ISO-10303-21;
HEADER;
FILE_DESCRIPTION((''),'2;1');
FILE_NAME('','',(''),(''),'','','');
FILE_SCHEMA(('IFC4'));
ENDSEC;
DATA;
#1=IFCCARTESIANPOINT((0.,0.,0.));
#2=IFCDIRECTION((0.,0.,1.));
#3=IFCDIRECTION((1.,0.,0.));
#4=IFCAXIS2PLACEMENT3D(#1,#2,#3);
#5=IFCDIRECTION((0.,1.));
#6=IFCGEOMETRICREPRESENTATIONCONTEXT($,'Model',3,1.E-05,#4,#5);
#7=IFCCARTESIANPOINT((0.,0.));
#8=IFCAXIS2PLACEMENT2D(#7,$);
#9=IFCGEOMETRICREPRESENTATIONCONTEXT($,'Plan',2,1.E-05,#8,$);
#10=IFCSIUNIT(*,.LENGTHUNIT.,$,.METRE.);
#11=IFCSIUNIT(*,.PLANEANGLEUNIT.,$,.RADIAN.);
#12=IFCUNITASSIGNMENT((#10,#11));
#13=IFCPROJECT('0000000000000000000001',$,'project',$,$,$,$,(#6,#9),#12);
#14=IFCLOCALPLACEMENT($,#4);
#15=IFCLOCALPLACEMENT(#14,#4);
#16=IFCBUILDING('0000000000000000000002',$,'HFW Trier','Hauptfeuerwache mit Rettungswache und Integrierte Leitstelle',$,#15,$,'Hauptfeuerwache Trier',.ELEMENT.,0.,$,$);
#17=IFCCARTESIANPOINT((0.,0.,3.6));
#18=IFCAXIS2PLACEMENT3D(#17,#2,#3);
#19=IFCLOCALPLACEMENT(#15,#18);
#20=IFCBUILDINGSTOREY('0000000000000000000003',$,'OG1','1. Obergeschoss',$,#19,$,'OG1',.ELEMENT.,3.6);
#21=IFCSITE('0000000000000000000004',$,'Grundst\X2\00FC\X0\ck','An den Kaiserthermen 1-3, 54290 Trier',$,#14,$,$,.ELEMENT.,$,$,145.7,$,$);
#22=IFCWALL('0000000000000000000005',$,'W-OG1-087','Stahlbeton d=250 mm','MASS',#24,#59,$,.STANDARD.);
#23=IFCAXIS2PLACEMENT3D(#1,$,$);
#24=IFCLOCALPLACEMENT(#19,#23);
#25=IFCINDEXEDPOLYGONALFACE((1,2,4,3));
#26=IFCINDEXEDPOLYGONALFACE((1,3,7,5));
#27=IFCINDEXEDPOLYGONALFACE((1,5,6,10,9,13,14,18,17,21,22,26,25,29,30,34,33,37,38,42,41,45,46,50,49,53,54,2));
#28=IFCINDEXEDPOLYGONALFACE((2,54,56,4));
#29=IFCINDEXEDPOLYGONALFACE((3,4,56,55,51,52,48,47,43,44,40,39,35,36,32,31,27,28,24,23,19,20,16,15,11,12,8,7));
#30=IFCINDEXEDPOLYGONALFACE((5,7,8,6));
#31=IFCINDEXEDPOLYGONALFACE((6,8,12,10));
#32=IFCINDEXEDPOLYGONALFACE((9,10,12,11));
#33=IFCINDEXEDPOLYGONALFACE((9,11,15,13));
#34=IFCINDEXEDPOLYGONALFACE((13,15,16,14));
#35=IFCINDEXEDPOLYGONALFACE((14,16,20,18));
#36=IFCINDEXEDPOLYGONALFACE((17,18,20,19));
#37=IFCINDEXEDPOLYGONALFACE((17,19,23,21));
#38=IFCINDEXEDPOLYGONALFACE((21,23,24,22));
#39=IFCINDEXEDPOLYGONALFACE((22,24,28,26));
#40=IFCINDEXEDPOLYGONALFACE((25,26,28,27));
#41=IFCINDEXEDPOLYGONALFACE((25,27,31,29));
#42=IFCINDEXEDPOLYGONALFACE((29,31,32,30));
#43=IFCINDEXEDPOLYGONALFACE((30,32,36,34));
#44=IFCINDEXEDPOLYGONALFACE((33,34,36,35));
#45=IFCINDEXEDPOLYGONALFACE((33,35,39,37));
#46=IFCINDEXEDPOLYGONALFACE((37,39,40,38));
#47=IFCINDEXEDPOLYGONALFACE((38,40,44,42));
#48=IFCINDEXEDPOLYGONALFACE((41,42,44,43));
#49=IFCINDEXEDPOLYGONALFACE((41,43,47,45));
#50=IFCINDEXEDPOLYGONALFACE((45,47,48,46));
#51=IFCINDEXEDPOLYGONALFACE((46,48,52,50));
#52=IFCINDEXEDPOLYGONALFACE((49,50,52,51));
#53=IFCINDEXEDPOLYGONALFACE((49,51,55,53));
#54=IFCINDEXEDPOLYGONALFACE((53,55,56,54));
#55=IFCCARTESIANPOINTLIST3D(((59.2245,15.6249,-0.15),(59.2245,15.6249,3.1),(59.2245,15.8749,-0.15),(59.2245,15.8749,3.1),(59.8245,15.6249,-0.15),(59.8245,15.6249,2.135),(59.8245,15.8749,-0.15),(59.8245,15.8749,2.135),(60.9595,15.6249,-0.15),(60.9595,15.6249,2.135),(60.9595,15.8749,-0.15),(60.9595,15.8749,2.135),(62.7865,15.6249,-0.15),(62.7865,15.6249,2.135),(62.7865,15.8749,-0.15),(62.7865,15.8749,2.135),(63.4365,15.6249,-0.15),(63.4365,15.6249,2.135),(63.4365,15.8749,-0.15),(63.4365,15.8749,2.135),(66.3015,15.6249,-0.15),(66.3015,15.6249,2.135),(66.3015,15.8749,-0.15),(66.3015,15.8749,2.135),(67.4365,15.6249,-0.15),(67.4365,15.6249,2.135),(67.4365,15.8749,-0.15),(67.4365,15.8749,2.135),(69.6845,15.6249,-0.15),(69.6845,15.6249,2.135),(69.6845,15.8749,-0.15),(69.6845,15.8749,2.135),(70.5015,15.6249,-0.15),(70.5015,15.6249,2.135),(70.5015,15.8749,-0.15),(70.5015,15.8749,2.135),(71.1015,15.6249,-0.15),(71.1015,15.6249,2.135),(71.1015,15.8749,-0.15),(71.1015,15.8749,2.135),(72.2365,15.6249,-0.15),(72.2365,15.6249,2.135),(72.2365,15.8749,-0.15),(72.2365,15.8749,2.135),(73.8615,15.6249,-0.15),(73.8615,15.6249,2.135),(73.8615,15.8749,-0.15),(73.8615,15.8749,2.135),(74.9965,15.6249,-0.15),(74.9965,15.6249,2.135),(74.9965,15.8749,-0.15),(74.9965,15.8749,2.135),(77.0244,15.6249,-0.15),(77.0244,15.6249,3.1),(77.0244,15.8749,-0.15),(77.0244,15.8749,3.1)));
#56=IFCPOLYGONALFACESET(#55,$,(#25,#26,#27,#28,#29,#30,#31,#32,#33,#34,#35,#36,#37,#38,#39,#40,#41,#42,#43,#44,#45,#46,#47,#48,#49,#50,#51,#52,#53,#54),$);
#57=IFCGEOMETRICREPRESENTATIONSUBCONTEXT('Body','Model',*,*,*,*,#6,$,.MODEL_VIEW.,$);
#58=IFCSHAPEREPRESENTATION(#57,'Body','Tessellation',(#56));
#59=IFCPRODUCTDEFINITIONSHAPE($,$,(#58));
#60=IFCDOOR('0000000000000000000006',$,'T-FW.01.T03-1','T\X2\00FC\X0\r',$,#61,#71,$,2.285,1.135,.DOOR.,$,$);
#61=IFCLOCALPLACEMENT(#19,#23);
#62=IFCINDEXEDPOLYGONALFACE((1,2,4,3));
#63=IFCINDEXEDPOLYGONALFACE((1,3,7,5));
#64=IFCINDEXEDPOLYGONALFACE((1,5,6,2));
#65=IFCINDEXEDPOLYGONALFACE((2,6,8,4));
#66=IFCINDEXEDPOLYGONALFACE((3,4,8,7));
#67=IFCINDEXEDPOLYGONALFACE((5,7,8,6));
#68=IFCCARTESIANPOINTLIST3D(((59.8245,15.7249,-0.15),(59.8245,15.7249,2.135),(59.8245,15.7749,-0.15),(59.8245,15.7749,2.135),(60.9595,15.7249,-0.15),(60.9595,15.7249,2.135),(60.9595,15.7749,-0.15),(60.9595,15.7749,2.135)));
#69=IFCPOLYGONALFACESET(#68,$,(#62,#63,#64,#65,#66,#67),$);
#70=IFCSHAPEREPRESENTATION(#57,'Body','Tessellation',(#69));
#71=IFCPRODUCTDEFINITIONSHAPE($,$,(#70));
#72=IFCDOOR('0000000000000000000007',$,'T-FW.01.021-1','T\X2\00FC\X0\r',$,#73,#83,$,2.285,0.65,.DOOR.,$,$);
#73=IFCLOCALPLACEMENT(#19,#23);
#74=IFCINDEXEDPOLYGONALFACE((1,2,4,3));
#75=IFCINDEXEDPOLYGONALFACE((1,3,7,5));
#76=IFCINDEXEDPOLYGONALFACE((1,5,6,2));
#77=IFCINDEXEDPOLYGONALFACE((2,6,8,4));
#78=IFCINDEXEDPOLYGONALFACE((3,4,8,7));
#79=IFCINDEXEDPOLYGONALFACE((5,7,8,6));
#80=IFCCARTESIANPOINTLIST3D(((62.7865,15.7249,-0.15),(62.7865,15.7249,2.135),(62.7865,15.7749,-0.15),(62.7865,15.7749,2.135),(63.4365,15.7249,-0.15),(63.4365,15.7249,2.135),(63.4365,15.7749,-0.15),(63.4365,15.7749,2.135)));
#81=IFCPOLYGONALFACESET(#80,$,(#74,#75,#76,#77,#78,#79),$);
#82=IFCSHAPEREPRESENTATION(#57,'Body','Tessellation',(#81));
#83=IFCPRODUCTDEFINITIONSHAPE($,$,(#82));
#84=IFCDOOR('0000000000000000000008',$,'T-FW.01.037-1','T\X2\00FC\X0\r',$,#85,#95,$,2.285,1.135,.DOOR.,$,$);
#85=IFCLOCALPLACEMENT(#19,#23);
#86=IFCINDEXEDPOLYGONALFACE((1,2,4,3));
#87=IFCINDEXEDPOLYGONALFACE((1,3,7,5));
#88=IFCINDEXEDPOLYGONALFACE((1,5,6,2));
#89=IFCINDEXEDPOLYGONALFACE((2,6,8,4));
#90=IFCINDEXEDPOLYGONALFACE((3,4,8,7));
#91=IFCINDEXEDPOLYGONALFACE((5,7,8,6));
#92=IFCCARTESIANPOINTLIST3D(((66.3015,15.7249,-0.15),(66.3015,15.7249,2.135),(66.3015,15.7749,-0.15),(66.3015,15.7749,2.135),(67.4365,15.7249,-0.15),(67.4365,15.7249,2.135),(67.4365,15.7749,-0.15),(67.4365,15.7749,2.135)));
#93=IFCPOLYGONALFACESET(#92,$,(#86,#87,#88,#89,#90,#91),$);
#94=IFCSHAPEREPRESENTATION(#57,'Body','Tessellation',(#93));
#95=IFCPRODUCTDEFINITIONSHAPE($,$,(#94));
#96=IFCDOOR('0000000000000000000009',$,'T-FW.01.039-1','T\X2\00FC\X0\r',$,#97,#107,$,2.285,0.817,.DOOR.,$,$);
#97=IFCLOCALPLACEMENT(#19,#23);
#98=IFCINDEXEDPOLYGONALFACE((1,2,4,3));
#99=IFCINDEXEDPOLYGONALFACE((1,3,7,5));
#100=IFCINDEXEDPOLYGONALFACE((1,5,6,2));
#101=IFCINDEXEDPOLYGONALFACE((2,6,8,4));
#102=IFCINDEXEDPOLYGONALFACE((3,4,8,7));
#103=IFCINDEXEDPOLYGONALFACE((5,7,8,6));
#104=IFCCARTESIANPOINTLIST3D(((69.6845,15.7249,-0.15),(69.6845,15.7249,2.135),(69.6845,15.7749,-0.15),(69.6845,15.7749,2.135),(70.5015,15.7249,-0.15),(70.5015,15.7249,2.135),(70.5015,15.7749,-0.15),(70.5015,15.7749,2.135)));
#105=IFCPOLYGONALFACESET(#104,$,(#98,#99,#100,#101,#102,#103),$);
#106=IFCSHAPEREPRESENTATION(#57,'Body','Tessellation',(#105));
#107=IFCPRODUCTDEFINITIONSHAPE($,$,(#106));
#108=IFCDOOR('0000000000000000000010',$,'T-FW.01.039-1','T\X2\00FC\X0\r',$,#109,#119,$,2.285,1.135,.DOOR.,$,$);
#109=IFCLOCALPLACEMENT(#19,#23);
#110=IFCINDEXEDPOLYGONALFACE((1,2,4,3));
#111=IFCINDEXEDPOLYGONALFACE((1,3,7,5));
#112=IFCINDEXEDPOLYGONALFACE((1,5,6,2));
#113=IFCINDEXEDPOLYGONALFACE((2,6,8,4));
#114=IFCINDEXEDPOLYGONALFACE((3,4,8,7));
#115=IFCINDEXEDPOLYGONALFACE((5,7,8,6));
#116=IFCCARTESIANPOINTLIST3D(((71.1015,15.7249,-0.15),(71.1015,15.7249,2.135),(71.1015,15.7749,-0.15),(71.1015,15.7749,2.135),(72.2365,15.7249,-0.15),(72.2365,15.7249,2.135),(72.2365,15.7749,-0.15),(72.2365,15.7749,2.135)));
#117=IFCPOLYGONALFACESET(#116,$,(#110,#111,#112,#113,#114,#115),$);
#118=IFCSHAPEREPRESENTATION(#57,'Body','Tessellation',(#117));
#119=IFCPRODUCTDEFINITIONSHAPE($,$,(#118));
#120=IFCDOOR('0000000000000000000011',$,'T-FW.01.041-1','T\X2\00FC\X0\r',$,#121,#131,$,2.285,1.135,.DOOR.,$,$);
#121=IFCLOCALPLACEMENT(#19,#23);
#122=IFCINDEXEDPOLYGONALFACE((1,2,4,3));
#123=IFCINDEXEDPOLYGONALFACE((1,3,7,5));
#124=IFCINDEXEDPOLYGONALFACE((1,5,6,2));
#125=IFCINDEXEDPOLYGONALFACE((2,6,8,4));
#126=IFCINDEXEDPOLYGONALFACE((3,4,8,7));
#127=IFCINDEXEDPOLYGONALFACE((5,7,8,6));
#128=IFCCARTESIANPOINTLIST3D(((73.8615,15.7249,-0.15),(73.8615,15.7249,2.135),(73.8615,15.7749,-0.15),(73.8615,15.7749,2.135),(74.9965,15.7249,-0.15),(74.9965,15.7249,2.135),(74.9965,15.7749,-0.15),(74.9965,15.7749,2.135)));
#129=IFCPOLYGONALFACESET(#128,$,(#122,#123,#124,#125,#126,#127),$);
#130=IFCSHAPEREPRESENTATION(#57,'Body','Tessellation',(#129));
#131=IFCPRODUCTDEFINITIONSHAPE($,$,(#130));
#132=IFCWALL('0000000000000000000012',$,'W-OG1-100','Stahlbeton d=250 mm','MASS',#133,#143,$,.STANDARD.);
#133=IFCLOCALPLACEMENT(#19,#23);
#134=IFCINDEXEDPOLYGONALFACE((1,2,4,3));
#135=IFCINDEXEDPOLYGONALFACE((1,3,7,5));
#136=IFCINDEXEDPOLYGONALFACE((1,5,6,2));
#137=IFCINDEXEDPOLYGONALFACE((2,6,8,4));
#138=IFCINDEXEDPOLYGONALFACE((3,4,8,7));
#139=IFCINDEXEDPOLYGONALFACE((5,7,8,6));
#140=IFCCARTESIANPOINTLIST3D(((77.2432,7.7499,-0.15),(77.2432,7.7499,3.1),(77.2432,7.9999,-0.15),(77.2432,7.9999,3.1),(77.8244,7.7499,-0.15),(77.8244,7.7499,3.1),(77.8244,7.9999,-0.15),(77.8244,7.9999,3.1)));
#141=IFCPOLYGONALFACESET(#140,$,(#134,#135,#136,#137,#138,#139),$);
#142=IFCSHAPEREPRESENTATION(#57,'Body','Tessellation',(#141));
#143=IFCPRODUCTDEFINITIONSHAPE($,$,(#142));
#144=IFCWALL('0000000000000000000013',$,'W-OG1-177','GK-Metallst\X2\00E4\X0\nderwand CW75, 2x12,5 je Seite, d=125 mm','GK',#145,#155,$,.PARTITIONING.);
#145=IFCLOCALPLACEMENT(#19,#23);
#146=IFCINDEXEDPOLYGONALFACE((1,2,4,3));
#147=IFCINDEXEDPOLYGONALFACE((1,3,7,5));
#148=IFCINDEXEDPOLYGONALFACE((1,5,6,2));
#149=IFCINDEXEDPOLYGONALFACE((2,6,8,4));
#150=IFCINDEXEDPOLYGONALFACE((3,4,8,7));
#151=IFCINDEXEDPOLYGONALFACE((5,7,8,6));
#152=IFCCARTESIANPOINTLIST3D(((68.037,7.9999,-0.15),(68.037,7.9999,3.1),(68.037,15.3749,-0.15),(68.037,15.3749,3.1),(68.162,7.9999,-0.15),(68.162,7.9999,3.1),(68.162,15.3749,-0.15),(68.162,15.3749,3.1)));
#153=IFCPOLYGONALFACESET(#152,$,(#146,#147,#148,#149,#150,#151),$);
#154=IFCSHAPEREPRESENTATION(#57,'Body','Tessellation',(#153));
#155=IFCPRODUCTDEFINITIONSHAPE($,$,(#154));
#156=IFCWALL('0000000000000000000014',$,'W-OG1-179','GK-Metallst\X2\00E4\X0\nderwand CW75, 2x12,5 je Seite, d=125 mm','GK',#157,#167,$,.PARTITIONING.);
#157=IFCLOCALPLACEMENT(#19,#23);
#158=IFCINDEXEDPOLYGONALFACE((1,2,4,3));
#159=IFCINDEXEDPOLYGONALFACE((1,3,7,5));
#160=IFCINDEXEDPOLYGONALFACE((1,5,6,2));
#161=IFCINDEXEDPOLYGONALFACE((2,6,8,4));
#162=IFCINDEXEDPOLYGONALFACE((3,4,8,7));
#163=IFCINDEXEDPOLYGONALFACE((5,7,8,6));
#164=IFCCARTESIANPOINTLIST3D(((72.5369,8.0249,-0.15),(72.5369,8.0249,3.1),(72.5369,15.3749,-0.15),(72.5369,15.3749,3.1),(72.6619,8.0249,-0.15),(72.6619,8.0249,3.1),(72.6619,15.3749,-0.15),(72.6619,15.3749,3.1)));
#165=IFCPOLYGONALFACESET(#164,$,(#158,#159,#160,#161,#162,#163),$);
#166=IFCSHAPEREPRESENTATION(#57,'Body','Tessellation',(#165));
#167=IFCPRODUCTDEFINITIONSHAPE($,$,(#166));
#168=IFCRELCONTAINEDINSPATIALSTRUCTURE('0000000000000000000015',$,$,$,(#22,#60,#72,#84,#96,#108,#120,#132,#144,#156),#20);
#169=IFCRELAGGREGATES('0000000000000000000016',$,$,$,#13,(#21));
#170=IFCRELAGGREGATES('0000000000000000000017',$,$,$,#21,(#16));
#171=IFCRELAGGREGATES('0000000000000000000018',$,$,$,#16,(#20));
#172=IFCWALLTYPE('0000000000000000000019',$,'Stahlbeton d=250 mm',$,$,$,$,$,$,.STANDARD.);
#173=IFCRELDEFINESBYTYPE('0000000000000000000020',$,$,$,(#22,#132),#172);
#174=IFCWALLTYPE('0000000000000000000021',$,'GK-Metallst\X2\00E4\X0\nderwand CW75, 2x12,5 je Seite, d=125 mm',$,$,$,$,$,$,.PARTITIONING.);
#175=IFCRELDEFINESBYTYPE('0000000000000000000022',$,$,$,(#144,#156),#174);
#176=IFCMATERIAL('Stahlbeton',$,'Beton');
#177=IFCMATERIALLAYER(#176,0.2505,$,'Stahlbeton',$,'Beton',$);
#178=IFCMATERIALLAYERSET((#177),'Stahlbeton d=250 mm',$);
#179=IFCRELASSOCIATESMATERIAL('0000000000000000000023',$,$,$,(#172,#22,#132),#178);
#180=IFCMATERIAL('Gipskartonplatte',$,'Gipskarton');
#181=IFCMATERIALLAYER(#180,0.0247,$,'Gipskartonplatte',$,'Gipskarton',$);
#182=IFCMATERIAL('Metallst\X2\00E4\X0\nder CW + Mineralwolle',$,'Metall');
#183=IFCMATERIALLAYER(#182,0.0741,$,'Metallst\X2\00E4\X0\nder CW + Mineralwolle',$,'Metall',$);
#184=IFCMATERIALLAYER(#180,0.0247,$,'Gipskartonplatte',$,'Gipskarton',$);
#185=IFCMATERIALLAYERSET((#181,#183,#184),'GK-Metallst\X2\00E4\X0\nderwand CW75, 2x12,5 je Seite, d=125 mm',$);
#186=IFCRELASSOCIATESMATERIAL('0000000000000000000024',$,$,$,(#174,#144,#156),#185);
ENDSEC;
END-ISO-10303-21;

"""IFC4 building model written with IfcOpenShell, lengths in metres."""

from ifc_helpers import new_model, si_unit, direction, frame, frame_2d, origin_with_axes, origin_2d, place, context, subcontext, project, spatial, rectangle, extrude, material, layer, layer_set, layer_usage, type_object, element, fill, save


model = new_model("IFC4")

# Units and contexts
model_context = context("Model", 3, precision=1e-05, world=origin_with_axes(), true_north=direction((0.0, 1.0)))
plan_context = context("Plan", 2, precision=1e-05, world=origin_2d())
body_context = subcontext(model_context, "Body", "Model", "MODEL_VIEW")
ifc_project = project(units=[si_unit("LENGTHUNIT", "METRE"), si_unit("PLANEANGLEUNIT", "RADIAN")], contexts=[model_context, plan_context])

# Site, building, storey
site_placement = place(None, origin_with_axes())
site = spatial("IfcSite", under=ifc_project, at=site_placement, Name="Grundstück", Description="An den Kaiserthermen 1-3, 54290 Trier", CompositionType="ELEMENT", RefElevation=145.7)
building_placement = place(site_placement, origin_with_axes())
building = spatial("IfcBuilding", under=site, at=building_placement, Name="HFW Trier", Description="Hauptfeuerwache mit Rettungswache und Integrierte Leitstelle", LongName="Hauptfeuerwache Trier", CompositionType="ELEMENT", ElevationOfRefHeight=0.0)
storey_placement = place(building_placement, frame((0.0, 0.0, 3.6), z_axis=(0.0, 0.0, 1.0), x_axis=(1.0, 0.0, 0.0)))
storey = spatial("IfcBuildingStorey", under=building, at=storey_placement, Name="OG1", Description="1. Obergeschoss", LongName="OG1", CompositionType="ELEMENT", Elevation=3.6)

# Wall, openings, doors
ifc_material_1 = material(Name="Stahlbeton", Category="Beton")
ifc_layer_1 = layer(ifc_material_1, 0.2505, Name="Stahlbeton", Category="Beton")
ifc_layer_set_1 = layer_set([ifc_layer_1], Name="Stahlbeton d=250 mm")
wall_type_1 = type_object("IfcWallType", Name="Stahlbeton d=250 mm", PredefinedType="STANDARD", material=ifc_layer_set_1)
ifc_layer_usage_1 = layer_usage(ifc_layer_set_1, "AXIS2", "POSITIVE", -0.125)
wall_1_placement = place(storey_placement, frame((59.2245, 15.7499, -0.15), z_axis=(0.0, 0.0, 1.0), x_axis=(1.0, 0.0, 0.0)))
wall_1 = element("IfcWall", 1, at=wall_1_placement, inside=storey, type_object=wall_type_1, material=ifc_layer_usage_1, Name="W-OG1-087", Description="Stahlbeton d=250 mm", ObjectType="MASS", PredefinedType="STANDARD", context=body_context, shape_type="SweptSolid", body=[
    extrude(rectangle(XDim=17.7999, YDim=0.25, at=frame_2d((8.9, 0.0))), origin_with_axes(), (0.0, 0.0, 1.0), 3.25),
])
opening_1_placement = place(wall_1_placement, frame((0.6, 0.0, 0.0), z_axis=(0.0, 0.0, 1.0), x_axis=(1.0, 0.0, 0.0)))
opening_1 = element("IfcOpeningElement", 2, at=opening_1_placement, cuts=wall_1, PredefinedType="OPENING", context=body_context, shape_type="SweptSolid", body=[
    extrude(rectangle(XDim=1.135, YDim=0.35, at=frame_2d((0.5675, 0.0))), origin_with_axes(), (0.0, 0.0, 1.0), 2.285),
])
opening_2_placement = place(wall_1_placement, frame((3.562, 0.0, 0.0), z_axis=(0.0, 0.0, 1.0), x_axis=(1.0, 0.0, 0.0)))
opening_2 = element("IfcOpeningElement", 3, at=opening_2_placement, cuts=wall_1, PredefinedType="OPENING", context=body_context, shape_type="SweptSolid", body=[
    extrude(rectangle(XDim=0.65, YDim=0.35, at=frame_2d((0.325, 0.0))), origin_with_axes(), (0.0, 0.0, 1.0), 2.285),
])
opening_3_placement = place(wall_1_placement, frame((7.077, 0.0, 0.0), z_axis=(0.0, 0.0, 1.0), x_axis=(1.0, 0.0, 0.0)))
opening_3 = element("IfcOpeningElement", 4, at=opening_3_placement, cuts=wall_1, PredefinedType="OPENING", context=body_context, shape_type="SweptSolid", body=[
    extrude(rectangle(XDim=1.135, YDim=0.35, at=frame_2d((0.5675, 0.0))), origin_with_axes(), (0.0, 0.0, 1.0), 2.285),
])
opening_4_placement = place(wall_1_placement, frame((10.46, 0.0, 0.0), z_axis=(0.0, 0.0, 1.0), x_axis=(1.0, 0.0, 0.0)))
opening_4 = element("IfcOpeningElement", 5, at=opening_4_placement, cuts=wall_1, PredefinedType="OPENING", context=body_context, shape_type="SweptSolid", body=[
    extrude(rectangle(XDim=0.817, YDim=0.35, at=frame_2d((0.4085, 0.0))), origin_with_axes(), (0.0, 0.0, 1.0), 2.285),
])
opening_5_placement = place(wall_1_placement, frame((11.877, 0.0, 0.0), z_axis=(0.0, 0.0, 1.0), x_axis=(1.0, 0.0, 0.0)))
opening_5 = element("IfcOpeningElement", 6, at=opening_5_placement, cuts=wall_1, PredefinedType="OPENING", context=body_context, shape_type="SweptSolid", body=[
    extrude(rectangle(XDim=1.135, YDim=0.35, at=frame_2d((0.5675, 0.0))), origin_with_axes(), (0.0, 0.0, 1.0), 2.285),
])
opening_6_placement = place(wall_1_placement, frame((14.637, 0.0, 0.0), z_axis=(0.0, 0.0, 1.0), x_axis=(1.0, 0.0, 0.0)))
opening_6 = element("IfcOpeningElement", 7, at=opening_6_placement, cuts=wall_1, PredefinedType="OPENING", context=body_context, shape_type="SweptSolid", body=[
    extrude(rectangle(XDim=1.135, YDim=0.35, at=frame_2d((0.5675, 0.0))), origin_with_axes(), (0.0, 0.0, 1.0), 2.285),
])
door_1_placement = place(wall_1_placement, frame((0.6, 0.0, 0.0), z_axis=(0.0, 0.0, 1.0), x_axis=(1.0, 0.0, 0.0)))
door_1 = element("IfcDoor", 8, at=door_1_placement, inside=storey, Name="T-FW.01.T03-1", Description="Tür", OverallHeight=2.285, OverallWidth=1.135, PredefinedType="DOOR", context=body_context, shape_type="SweptSolid", body=[
    extrude(rectangle(XDim=1.135, YDim=0.05, at=frame_2d((0.5675, 0.0))), origin_with_axes(), (0.0, 0.0, 1.0), 2.285),
])
fill(opening_1, door_1)
door_2_placement = place(wall_1_placement, frame((3.562, 0.0, 0.0), z_axis=(0.0, 0.0, 1.0), x_axis=(1.0, 0.0, 0.0)))
door_2 = element("IfcDoor", 9, at=door_2_placement, inside=storey, Name="T-FW.01.021-1", Description="Tür", OverallHeight=2.285, OverallWidth=0.65, PredefinedType="DOOR", context=body_context, shape_type="SweptSolid", body=[
    extrude(rectangle(XDim=0.65, YDim=0.05, at=frame_2d((0.325, 0.0))), origin_with_axes(), (0.0, 0.0, 1.0), 2.285),
])
fill(opening_2, door_2)
door_3_placement = place(wall_1_placement, frame((7.077, 0.0, 0.0), z_axis=(0.0, 0.0, 1.0), x_axis=(1.0, 0.0, 0.0)))
door_3 = element("IfcDoor", 10, at=door_3_placement, inside=storey, Name="T-FW.01.037-1", Description="Tür", OverallHeight=2.285, OverallWidth=1.135, PredefinedType="DOOR", context=body_context, shape_type="SweptSolid", body=[
    extrude(rectangle(XDim=1.135, YDim=0.05, at=frame_2d((0.5675, 0.0))), origin_with_axes(), (0.0, 0.0, 1.0), 2.285),
])
fill(opening_3, door_3)
door_4_placement = place(wall_1_placement, frame((10.46, 0.0, 0.0), z_axis=(0.0, 0.0, 1.0), x_axis=(1.0, 0.0, 0.0)))
door_4 = element("IfcDoor", 11, at=door_4_placement, inside=storey, Name="T-FW.01.039-1", Description="Tür", OverallHeight=2.285, OverallWidth=0.817, PredefinedType="DOOR", context=body_context, shape_type="SweptSolid", body=[
    extrude(rectangle(XDim=0.817, YDim=0.05, at=frame_2d((0.4085, 0.0))), origin_with_axes(), (0.0, 0.0, 1.0), 2.285),
])
fill(opening_4, door_4)
door_5_placement = place(wall_1_placement, frame((11.877, 0.0, 0.0), z_axis=(0.0, 0.0, 1.0), x_axis=(1.0, 0.0, 0.0)))
door_5 = element("IfcDoor", 12, at=door_5_placement, inside=storey, Name="T-FW.01.039-1", Description="Tür", OverallHeight=2.285, OverallWidth=1.135, PredefinedType="DOOR", context=body_context, shape_type="SweptSolid", body=[
    extrude(rectangle(XDim=1.135, YDim=0.05, at=frame_2d((0.5675, 0.0))), origin_with_axes(), (0.0, 0.0, 1.0), 2.285),
])
fill(opening_5, door_5)
door_6_placement = place(wall_1_placement, frame((14.637, 0.0, 0.0), z_axis=(0.0, 0.0, 1.0), x_axis=(1.0, 0.0, 0.0)))
door_6 = element("IfcDoor", 13, at=door_6_placement, inside=storey, Name="T-FW.01.041-1", Description="Tür", OverallHeight=2.285, OverallWidth=1.135, PredefinedType="DOOR", context=body_context, shape_type="SweptSolid", body=[
    extrude(rectangle(XDim=1.135, YDim=0.05, at=frame_2d((0.5675, 0.0))), origin_with_axes(), (0.0, 0.0, 1.0), 2.285),
])
fill(opening_6, door_6)

# Walls
ifc_layer_usage_2 = layer_usage(ifc_layer_set_1, "AXIS2", "POSITIVE", -0.125)
wall_2_placement = place(storey_placement, frame((77.2432, 7.8749, -0.15), z_axis=(0.0, 0.0, 1.0), x_axis=(1.0, 0.0, 0.0)))
element("IfcWall", 14, at=wall_2_placement, inside=storey, type_object=wall_type_1, material=ifc_layer_usage_2, Name="W-OG1-100", Description="Stahlbeton d=250 mm", ObjectType="MASS", PredefinedType="STANDARD", context=body_context, shape_type="SweptSolid", body=[
    extrude(rectangle(XDim=0.5812, YDim=0.25, at=frame_2d((0.2906, 0.0))), origin_with_axes(), (0.0, 0.0, 1.0), 3.25),
])
ifc_material_2 = material(Name="Gipskartonplatte", Category="Gipskarton")
ifc_layer_2 = layer(ifc_material_2, 0.0247, Name="Gipskartonplatte", Category="Gipskarton")
ifc_material_3 = material(Name="Metallständer CW + Mineralwolle", Category="Metall")
ifc_layer_3 = layer(ifc_material_3, 0.0741, Name="Metallständer CW + Mineralwolle", Category="Metall")
ifc_layer_4 = layer(ifc_material_2, 0.0247, Name="Gipskartonplatte", Category="Gipskarton")
ifc_layer_set_2 = layer_set([ifc_layer_2, ifc_layer_3, ifc_layer_4], Name="GK-Metallständerwand CW75, 2x12,5 je Seite, d=125 mm")
ifc_layer_usage_3 = layer_usage(ifc_layer_set_2, "AXIS2", "POSITIVE", -0.0625)
wall_type_2 = type_object("IfcWallType", Name="GK-Metallständerwand CW75, 2x12,5 je Seite, d=125 mm", PredefinedType="PARTITIONING", material=ifc_layer_set_2)
wall_3_placement = place(storey_placement, frame((68.0995, 15.3749, -0.15), z_axis=(0.0, 0.0, 1.0), x_axis=(0.0, -1.0, 0.0)))
element("IfcWall", 15, at=wall_3_placement, inside=storey, type_object=wall_type_2, material=ifc_layer_usage_3, Name="W-OG1-177", Description="GK-Metallständerwand CW75, 2x12,5 je Seite, d=125 mm", ObjectType="GK", PredefinedType="PARTITIONING", context=body_context, shape_type="SweptSolid", body=[
    extrude(rectangle(XDim=7.375, YDim=0.125, at=frame_2d((3.6875, 0.0))), origin_with_axes(), (0.0, 0.0, 1.0), 3.25),
])
ifc_layer_usage_4 = layer_usage(ifc_layer_set_2, "AXIS2", "POSITIVE", -0.0625)
wall_4_placement = place(storey_placement, frame((72.5994, 15.3749, -0.15), z_axis=(0.0, 0.0, 1.0), x_axis=(0.0, -1.0, 0.0)))
element("IfcWall", 16, at=wall_4_placement, inside=storey, type_object=wall_type_2, material=ifc_layer_usage_4, Name="W-OG1-179", Description="GK-Metallständerwand CW75, 2x12,5 je Seite, d=125 mm", ObjectType="GK", PredefinedType="PARTITIONING", context=body_context, shape_type="SweptSolid", body=[
    extrude(rectangle(XDim=7.35, YDim=0.125, at=frame_2d((3.675, 0.0))), origin_with_axes(), (0.0, 0.0, 1.0), 3.25),
])

save(model, "model.ifc")
